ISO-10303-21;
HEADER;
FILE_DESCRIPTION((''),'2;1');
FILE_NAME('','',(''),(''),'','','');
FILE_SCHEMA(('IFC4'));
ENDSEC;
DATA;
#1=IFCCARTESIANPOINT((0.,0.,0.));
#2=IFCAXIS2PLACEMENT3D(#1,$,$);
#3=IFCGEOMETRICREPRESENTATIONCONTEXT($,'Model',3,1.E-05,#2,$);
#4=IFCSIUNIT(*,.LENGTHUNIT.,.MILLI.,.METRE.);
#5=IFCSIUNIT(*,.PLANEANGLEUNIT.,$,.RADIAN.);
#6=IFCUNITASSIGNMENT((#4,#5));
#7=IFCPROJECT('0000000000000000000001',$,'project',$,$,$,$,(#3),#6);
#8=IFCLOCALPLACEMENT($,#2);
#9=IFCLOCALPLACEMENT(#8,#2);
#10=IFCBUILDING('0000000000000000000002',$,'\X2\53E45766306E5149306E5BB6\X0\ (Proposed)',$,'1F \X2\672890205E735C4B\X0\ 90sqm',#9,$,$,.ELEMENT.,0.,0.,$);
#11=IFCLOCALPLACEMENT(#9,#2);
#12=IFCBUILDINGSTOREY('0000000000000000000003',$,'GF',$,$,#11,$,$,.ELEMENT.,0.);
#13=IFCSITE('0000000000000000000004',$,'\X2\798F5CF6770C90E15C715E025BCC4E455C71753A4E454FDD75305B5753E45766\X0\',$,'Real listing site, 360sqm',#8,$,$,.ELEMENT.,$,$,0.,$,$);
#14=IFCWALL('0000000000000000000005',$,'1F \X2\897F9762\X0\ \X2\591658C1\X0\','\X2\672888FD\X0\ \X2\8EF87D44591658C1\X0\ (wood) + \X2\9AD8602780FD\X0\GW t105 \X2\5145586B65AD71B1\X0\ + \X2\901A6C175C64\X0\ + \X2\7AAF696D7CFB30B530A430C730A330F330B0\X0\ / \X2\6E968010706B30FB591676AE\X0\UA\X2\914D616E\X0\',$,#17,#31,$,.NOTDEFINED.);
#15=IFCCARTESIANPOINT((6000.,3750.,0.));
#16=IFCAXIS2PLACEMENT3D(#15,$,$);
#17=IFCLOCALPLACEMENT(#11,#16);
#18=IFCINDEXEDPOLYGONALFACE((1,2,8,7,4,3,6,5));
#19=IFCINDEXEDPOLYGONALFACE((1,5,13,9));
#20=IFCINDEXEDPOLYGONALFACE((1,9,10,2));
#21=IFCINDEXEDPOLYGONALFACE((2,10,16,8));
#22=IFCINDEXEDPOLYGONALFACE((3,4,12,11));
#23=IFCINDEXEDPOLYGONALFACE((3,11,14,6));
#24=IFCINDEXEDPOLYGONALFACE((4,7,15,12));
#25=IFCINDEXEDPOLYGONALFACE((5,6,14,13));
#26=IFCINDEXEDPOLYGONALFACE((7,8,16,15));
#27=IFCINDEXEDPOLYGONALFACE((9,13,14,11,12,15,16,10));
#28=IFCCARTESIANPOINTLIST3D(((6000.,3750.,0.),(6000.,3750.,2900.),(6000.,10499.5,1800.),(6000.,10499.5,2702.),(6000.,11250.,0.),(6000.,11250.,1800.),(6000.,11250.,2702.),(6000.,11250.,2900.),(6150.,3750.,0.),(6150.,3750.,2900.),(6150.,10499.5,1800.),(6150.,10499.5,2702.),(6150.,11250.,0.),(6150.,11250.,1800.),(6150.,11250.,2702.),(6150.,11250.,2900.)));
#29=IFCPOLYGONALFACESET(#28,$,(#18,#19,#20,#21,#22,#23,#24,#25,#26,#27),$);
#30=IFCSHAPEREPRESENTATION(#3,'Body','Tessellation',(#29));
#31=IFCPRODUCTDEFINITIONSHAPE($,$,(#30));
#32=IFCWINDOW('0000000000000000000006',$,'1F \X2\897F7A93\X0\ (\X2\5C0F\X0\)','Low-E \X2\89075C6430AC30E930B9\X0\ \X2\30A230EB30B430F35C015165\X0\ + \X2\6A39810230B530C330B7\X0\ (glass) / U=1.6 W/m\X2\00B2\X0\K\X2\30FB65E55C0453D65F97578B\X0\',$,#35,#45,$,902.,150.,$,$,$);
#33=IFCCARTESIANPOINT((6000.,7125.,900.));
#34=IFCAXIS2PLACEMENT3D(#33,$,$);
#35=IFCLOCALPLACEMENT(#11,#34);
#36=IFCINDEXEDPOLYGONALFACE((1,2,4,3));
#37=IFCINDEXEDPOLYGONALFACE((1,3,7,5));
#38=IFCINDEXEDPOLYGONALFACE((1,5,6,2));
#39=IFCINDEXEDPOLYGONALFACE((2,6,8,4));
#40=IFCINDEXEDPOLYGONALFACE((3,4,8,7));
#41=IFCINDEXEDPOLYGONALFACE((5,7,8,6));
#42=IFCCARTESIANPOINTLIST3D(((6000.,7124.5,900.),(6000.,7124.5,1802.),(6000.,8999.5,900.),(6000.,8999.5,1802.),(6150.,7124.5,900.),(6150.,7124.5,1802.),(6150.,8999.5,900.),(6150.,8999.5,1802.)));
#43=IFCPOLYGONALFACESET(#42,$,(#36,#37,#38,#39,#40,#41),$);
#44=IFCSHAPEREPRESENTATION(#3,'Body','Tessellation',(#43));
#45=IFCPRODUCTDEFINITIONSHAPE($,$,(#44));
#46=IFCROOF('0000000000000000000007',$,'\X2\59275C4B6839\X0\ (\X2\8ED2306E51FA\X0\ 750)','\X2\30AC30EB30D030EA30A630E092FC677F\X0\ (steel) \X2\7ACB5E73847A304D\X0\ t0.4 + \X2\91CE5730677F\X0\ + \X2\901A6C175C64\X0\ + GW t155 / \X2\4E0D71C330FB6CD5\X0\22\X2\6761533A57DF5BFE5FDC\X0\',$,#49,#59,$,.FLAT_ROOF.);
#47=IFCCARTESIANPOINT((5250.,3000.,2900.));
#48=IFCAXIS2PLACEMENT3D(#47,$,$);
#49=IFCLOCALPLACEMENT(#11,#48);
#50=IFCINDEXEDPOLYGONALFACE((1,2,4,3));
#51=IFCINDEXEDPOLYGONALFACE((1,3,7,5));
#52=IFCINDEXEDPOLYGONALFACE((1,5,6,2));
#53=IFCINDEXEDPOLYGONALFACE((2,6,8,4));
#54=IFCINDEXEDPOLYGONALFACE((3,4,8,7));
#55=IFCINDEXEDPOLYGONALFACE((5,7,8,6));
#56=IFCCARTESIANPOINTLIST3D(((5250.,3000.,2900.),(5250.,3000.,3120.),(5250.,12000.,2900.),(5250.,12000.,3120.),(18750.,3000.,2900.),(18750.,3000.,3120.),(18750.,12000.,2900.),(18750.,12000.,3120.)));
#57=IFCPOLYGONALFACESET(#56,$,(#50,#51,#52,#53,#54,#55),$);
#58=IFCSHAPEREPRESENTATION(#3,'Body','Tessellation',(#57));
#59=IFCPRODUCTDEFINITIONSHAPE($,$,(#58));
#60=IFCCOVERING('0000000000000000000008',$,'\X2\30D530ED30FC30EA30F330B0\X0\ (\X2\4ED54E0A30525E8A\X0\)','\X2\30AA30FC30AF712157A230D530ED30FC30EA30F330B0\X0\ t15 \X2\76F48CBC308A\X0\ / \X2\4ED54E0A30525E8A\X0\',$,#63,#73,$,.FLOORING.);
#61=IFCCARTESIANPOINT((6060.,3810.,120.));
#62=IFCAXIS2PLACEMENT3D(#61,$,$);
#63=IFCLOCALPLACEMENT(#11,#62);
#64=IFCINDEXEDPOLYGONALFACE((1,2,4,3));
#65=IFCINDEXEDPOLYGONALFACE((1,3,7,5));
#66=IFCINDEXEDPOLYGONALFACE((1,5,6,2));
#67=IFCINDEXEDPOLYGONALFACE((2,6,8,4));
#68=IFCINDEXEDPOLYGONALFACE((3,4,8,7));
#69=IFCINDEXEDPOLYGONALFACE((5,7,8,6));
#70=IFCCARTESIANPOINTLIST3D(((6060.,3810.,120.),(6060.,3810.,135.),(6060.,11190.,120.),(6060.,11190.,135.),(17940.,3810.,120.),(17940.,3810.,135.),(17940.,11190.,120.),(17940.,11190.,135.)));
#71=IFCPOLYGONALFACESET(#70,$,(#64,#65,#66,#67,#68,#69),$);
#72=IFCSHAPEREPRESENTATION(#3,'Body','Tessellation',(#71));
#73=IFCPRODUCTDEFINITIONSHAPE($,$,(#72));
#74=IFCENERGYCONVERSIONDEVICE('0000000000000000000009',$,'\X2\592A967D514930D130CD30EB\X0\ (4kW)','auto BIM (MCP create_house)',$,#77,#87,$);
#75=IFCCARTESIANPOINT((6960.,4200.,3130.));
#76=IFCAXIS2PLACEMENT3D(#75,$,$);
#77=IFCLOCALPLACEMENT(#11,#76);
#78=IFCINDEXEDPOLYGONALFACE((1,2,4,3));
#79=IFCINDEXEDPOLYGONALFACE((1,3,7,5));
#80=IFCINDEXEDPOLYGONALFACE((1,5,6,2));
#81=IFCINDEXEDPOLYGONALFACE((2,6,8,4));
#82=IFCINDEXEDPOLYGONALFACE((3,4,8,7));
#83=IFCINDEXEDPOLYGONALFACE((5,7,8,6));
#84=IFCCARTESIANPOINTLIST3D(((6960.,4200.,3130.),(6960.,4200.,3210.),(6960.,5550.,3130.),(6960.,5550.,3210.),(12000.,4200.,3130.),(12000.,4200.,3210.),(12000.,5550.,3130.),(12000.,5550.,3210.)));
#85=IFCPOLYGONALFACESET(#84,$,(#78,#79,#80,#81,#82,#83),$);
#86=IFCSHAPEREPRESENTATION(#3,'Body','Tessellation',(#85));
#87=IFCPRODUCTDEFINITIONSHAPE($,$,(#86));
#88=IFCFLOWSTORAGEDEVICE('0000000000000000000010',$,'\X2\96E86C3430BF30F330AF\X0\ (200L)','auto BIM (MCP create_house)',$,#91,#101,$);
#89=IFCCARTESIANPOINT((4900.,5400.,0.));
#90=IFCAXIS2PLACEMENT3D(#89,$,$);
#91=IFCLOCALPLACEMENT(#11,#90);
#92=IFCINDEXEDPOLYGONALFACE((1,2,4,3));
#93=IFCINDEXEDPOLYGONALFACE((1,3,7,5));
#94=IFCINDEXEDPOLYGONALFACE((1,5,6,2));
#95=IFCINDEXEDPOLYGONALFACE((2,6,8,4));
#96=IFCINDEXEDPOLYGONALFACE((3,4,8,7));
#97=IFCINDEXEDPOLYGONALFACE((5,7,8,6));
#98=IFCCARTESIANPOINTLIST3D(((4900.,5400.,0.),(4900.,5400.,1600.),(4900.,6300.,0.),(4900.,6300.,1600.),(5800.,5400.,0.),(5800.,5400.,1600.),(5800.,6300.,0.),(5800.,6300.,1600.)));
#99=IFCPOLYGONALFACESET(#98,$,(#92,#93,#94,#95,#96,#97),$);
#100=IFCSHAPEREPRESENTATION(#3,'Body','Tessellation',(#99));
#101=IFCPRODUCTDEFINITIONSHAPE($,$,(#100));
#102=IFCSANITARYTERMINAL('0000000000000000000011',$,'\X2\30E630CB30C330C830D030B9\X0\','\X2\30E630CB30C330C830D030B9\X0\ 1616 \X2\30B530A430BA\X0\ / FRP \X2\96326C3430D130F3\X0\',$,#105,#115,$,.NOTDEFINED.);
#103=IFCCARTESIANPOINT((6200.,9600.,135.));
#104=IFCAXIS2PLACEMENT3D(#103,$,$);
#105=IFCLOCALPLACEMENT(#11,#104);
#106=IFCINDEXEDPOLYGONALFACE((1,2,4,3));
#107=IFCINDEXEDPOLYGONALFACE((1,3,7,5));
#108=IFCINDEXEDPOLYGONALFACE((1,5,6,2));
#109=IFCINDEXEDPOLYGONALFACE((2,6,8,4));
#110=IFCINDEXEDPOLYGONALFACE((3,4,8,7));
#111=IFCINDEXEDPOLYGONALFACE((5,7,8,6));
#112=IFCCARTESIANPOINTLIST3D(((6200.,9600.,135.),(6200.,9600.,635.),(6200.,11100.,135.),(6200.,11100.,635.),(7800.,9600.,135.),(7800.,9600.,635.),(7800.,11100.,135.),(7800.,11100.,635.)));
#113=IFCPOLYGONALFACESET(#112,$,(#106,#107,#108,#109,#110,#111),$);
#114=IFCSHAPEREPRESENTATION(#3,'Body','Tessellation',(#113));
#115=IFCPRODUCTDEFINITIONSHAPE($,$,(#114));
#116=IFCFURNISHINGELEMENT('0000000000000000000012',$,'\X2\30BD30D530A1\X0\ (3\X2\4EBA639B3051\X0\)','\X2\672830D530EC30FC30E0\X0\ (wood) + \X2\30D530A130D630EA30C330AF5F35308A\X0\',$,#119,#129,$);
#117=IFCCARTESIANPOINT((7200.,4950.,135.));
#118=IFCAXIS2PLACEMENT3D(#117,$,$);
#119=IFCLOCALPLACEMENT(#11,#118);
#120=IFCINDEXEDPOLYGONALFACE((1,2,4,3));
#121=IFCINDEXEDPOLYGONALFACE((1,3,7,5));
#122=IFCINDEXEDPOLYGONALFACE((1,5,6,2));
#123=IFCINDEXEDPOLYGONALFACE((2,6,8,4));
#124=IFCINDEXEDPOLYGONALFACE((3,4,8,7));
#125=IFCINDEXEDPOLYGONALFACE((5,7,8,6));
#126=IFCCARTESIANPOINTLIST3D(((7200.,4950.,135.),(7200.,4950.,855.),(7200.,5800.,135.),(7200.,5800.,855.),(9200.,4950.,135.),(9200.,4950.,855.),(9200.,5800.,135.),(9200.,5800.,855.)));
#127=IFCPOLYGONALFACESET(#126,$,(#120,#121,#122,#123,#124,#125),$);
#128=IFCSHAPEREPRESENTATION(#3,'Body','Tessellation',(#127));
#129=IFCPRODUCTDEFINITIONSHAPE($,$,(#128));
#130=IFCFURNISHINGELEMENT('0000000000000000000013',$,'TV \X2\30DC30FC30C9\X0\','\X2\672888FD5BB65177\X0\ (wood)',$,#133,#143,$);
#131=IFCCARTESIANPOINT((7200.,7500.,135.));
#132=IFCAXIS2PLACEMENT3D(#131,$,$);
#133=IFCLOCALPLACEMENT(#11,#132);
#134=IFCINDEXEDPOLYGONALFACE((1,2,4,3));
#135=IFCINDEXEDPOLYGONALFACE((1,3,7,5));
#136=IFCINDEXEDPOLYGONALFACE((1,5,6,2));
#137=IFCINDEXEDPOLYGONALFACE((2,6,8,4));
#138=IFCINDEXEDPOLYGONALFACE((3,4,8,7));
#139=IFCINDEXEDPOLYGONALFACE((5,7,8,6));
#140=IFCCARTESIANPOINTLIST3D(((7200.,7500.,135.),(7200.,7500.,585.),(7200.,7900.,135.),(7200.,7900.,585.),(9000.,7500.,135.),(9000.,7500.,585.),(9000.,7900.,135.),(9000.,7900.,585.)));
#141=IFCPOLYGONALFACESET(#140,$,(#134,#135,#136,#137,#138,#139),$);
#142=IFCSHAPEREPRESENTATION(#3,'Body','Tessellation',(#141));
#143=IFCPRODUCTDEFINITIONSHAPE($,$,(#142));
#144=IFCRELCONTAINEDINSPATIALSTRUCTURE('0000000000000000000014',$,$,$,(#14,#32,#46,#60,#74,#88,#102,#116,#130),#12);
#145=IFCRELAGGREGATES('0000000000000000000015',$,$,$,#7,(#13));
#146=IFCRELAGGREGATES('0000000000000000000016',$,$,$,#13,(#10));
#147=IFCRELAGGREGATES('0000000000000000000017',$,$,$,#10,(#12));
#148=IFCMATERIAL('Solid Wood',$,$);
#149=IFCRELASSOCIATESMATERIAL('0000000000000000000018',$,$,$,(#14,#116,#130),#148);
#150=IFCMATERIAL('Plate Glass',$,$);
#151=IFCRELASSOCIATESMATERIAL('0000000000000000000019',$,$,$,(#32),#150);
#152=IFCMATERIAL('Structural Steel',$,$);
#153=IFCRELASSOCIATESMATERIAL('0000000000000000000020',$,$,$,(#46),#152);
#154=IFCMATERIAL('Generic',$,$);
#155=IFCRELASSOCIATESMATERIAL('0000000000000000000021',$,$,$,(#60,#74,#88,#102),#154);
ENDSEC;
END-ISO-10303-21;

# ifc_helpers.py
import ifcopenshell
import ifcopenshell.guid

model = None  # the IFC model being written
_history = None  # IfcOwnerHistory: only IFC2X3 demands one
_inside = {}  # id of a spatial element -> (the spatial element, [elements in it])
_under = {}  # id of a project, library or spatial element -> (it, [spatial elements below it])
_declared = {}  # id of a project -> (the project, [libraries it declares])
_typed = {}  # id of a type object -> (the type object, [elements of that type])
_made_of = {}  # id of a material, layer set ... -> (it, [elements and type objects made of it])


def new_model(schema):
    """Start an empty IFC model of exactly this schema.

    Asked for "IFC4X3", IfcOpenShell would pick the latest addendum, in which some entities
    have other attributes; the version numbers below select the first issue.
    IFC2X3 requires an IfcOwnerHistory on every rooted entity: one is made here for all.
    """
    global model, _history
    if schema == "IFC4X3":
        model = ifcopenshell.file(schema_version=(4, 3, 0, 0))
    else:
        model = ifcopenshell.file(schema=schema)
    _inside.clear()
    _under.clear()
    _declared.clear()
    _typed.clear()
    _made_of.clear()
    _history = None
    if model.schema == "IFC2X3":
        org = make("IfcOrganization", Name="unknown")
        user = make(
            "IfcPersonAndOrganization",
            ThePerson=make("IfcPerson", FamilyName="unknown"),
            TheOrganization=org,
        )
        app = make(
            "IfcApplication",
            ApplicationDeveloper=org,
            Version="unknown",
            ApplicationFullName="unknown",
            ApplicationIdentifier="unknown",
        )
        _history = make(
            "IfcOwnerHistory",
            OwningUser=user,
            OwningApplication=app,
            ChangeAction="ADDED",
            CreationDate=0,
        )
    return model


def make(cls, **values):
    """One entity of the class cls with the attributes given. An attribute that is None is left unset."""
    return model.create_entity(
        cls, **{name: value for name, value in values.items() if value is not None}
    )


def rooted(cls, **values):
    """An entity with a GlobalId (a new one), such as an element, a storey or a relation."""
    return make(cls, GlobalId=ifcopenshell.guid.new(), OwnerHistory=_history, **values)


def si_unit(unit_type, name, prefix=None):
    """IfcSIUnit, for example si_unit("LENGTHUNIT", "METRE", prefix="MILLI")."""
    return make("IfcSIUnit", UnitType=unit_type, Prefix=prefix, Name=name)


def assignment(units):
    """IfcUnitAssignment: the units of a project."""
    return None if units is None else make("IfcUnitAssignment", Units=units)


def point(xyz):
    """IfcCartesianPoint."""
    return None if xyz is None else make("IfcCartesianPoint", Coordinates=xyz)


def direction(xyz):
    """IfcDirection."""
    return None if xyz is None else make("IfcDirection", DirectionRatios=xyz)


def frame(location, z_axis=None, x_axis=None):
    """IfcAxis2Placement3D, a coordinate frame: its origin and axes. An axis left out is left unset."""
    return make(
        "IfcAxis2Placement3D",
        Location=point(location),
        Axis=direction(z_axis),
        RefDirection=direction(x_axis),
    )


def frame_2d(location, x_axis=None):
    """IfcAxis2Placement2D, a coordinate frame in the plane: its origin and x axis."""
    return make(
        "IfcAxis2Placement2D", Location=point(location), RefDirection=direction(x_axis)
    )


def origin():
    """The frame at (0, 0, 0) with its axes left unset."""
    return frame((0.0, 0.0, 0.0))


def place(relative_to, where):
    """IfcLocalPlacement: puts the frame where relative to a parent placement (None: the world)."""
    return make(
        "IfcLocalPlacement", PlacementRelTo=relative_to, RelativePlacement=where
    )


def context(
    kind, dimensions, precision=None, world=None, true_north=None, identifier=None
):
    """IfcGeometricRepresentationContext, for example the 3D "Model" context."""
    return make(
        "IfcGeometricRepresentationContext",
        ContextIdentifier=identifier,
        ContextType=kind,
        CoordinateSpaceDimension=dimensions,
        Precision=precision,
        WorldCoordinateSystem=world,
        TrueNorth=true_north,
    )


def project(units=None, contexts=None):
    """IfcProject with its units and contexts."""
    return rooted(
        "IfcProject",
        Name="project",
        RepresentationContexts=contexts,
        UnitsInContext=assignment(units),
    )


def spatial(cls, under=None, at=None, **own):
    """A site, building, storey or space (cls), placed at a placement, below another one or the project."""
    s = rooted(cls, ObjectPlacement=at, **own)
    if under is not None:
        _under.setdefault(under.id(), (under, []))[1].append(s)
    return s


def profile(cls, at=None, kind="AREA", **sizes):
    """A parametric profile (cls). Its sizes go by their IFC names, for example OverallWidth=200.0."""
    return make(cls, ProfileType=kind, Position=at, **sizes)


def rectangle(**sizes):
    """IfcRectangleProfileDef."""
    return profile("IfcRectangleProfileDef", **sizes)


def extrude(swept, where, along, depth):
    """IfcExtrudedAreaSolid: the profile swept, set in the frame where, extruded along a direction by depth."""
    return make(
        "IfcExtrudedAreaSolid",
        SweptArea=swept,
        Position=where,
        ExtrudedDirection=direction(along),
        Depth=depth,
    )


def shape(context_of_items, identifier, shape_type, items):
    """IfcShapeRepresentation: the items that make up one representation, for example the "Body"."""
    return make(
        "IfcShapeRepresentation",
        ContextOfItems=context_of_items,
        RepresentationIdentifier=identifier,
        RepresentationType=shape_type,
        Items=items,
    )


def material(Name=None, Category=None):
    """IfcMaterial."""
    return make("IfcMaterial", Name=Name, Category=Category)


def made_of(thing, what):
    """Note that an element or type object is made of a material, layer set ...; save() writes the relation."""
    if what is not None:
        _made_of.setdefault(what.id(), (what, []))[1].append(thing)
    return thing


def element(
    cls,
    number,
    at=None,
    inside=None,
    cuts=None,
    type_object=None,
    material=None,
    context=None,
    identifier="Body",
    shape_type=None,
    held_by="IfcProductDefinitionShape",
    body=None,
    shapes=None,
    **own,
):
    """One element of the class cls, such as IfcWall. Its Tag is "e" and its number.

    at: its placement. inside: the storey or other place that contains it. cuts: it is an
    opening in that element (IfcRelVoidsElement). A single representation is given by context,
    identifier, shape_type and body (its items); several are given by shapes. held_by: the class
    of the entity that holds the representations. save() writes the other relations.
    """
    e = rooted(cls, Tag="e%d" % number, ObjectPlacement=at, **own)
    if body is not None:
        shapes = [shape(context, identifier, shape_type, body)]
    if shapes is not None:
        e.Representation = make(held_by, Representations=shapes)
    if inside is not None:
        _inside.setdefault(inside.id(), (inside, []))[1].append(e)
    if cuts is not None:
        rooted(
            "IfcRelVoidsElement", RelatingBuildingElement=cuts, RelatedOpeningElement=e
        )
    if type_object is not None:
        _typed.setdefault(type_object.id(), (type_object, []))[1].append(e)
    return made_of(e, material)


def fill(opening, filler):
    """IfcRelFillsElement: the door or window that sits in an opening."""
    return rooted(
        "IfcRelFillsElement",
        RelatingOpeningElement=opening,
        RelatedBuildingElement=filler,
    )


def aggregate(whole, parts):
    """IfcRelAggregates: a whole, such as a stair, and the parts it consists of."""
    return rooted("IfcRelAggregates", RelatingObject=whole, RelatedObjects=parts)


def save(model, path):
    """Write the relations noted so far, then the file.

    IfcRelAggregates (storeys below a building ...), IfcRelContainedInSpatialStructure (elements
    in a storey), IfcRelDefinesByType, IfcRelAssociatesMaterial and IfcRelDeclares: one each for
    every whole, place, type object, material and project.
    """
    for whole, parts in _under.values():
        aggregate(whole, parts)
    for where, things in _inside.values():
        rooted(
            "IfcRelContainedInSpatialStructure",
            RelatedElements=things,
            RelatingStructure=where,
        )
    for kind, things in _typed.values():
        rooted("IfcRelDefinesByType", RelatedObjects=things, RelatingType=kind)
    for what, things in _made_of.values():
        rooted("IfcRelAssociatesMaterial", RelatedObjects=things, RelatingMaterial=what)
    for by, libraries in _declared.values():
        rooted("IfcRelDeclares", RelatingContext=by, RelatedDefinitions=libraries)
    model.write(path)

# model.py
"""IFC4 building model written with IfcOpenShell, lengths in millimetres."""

from ifc_helpers import new_model, si_unit, frame, frame_2d, origin, place, context, project, spatial, rectangle, extrude, material, element, fill, save


model = new_model("IFC4")

# Units and contexts
model_context = context("Model", 3, precision=1e-05, world=origin())
ifc_project = project(units=[si_unit("LENGTHUNIT", "METRE", prefix="MILLI"), si_unit("PLANEANGLEUNIT", "RADIAN")], contexts=[model_context])

# Site, building, storey
site_placement = place(None, origin())
site = spatial("IfcSite", under=ifc_project, at=site_placement, Name="福島県郡山市富久山町久保田字古坦", ObjectType="Real listing site, 360sqm", CompositionType="ELEMENT", RefElevation=0.0)
building_placement = place(site_placement, origin())
building = spatial("IfcBuilding", under=site, at=building_placement, Name="古坦の光の家 (Proposed)", ObjectType="1F 木造平屋 90sqm", CompositionType="ELEMENT", ElevationOfRefHeight=0.0, ElevationOfTerrain=0.0)
storey_placement = place(building_placement, origin())
storey = spatial("IfcBuildingStorey", under=building, at=storey_placement, Name="GF", CompositionType="ELEMENT", Elevation=0.0)

# Shared definitions
ifc_material_1 = material(Name="Solid Wood")

# Shared definitions
ifc_material_2 = material(Name="Plate Glass")

# Wall, opening, window
wall_1_placement = place(storey_placement, frame((6000.0, 3750.0, 0.0)))
wall_1 = element("IfcWall", 1, at=wall_1_placement, inside=storey, material=ifc_material_1, Name="1F 西面 外壁", Description="木製 軸組外壁 (wood) + 高性能GW t105 充填断熱 + 通気層 + 窯業系サイディング / 準耐火・外皮UA配慮", PredefinedType="NOTDEFINED", context=model_context, shape_type="SweptSolid", body=[
    extrude(rectangle(XDim=150.0, YDim=7500.0, at=frame_2d((75.0, 3750.0))), frame((6000.0, 3750.0, 0.0)), (0.0, 0.0, 1.0), 2900.0),
])
opening_1_placement = place(storey_placement, frame((6000.0, 7125.0, 900.0)))
opening_1 = element("IfcOpeningElement", 2, at=opening_1_placement, cuts=wall_1, PredefinedType="NOTDEFINED", context=model_context, shape_type="SweptSolid", body=[
    extrude(rectangle(XDim=150.0, YDim=1875.0, at=frame_2d((75.0, 937.0))), frame((6000.0, 7125.0, 900.0)), (0.0, 0.0, 1.0), 902.0),
])
window_1_placement = place(storey_placement, frame((6000.0, 7125.0, 900.0)))
window_1 = element("IfcWindow", 3, at=window_1_placement, inside=storey, material=ifc_material_2, Name="1F 西窓 (小)", Description="Low-E 複層ガラス アルゴン封入 + 樹脂サッシ (glass) / U=1.6 W/m²K・日射取得型", OverallHeight=902.0, OverallWidth=150.0, context=model_context, shape_type="SweptSolid", body=[
    extrude(rectangle(XDim=150.0, YDim=1875.0, at=frame_2d((75.0, 937.0))), frame((6000.0, 7125.0, 900.0)), (0.0, 0.0, 1.0), 902.0),
])
fill(opening_1, window_1)

# Roof
ifc_material_3 = material(Name="Structural Steel")
roof_placement = place(storey_placement, frame((5250.0, 3000.0, 2900.0)))
element("IfcRoof", 4, at=roof_placement, inside=storey, material=ifc_material_3, Name="大屋根 (軒の出 750)", Description="ガルバリウム鋼板 (steel) 立平葺き t0.4 + 野地板 + 通気層 + GW t155 / 不燃・法22条区域対応", PredefinedType="FLAT_ROOF", context=model_context, shape_type="SweptSolid", body=[
    extrude(rectangle(XDim=13500.0, YDim=9000.0, at=frame_2d((6750.0, 4500.0))), frame((5250.0, 3000.0, 2900.0)), (0.0, 0.0, 1.0), 220.0),
])

# Covering
ifc_material_4 = material(Name="Generic")
covering_placement = place(storey_placement, frame((6060.0, 3810.0, 120.0)))
element("IfcCovering", 5, at=covering_placement, inside=storey, material=ifc_material_4, Name="フローリング (仕上げ床)", Description="オーク無垢フローリング t15 直貼り / 仕上げ床", PredefinedType="FLOORING", context=model_context, shape_type="SweptSolid", body=[
    extrude(rectangle(XDim=11880.0, YDim=7380.0, at=frame_2d((5940.0, 3690.0))), frame((6060.0, 3810.0, 120.0)), (0.0, 0.0, 1.0), 15.0),
])

# Energy conversion device
energy_conversion_device_placement = place(storey_placement, frame((6960.0, 4200.0, 3130.0)))
element("IfcEnergyConversionDevice", 6, at=energy_conversion_device_placement, inside=storey, material=ifc_material_4, Name="太陽光パネル (4kW)", Description="auto BIM (MCP create_house)", context=model_context, shape_type="SweptSolid", body=[
    extrude(rectangle(XDim=5040.0, YDim=1350.0, at=frame_2d((2520.0, 675.0))), frame((6960.0, 4200.0, 3130.0)), (0.0, 0.0, 1.0), 80.0),
])

# Flow storage device
flow_storage_device_placement = place(storey_placement, frame((4900.0, 5400.0, 0.0)))
element("IfcFlowStorageDevice", 7, at=flow_storage_device_placement, inside=storey, material=ifc_material_4, Name="雨水タンク (200L)", Description="auto BIM (MCP create_house)", context=model_context, shape_type="SweptSolid", body=[
    extrude(rectangle(XDim=900.0, YDim=900.0, at=frame_2d((450.0, 450.0))), frame((4900.0, 5400.0, 0.0)), (0.0, 0.0, 1.0), 1600.0),
])

# Sanitary terminal
sanitary_terminal_placement = place(storey_placement, frame((6200.0, 9600.0, 135.0)))
element("IfcSanitaryTerminal", 8, at=sanitary_terminal_placement, inside=storey, material=ifc_material_4, Name="ユニットバス", Description="ユニットバス 1616 サイズ / FRP 防水パン", PredefinedType="NOTDEFINED", context=model_context, shape_type="SweptSolid", body=[
    extrude(rectangle(XDim=1600.0, YDim=1500.0, at=frame_2d((800.0, 750.0))), frame((6200.0, 9600.0, 135.0)), (0.0, 0.0, 1.0), 500.0),
])

# Furnishing elements
furnishing_1_placement = place(storey_placement, frame((7200.0, 4950.0, 135.0)))
element("IfcFurnishingElement", 9, at=furnishing_1_placement, inside=storey, material=ifc_material_1, Name="ソファ (3人掛け)", Description="木フレーム (wood) + ファブリック張り", context=model_context, shape_type="SweptSolid", body=[
    extrude(rectangle(XDim=2000.0, YDim=850.0, at=frame_2d((1000.0, 425.0))), frame((7200.0, 4950.0, 135.0)), (0.0, 0.0, 1.0), 720.0),
])
furnishing_2_placement = place(storey_placement, frame((7200.0, 7500.0, 135.0)))
element("IfcFurnishingElement", 10, at=furnishing_2_placement, inside=storey, material=ifc_material_1, Name="TV ボード", Description="木製家具 (wood)", context=model_context, shape_type="SweptSolid", body=[
    extrude(rectangle(XDim=1800.0, YDim=400.0, at=frame_2d((900.0, 200.0))), frame((7200.0, 7500.0, 135.0)), (0.0, 0.0, 1.0), 450.0),
])

save(model, "model.ifc")
